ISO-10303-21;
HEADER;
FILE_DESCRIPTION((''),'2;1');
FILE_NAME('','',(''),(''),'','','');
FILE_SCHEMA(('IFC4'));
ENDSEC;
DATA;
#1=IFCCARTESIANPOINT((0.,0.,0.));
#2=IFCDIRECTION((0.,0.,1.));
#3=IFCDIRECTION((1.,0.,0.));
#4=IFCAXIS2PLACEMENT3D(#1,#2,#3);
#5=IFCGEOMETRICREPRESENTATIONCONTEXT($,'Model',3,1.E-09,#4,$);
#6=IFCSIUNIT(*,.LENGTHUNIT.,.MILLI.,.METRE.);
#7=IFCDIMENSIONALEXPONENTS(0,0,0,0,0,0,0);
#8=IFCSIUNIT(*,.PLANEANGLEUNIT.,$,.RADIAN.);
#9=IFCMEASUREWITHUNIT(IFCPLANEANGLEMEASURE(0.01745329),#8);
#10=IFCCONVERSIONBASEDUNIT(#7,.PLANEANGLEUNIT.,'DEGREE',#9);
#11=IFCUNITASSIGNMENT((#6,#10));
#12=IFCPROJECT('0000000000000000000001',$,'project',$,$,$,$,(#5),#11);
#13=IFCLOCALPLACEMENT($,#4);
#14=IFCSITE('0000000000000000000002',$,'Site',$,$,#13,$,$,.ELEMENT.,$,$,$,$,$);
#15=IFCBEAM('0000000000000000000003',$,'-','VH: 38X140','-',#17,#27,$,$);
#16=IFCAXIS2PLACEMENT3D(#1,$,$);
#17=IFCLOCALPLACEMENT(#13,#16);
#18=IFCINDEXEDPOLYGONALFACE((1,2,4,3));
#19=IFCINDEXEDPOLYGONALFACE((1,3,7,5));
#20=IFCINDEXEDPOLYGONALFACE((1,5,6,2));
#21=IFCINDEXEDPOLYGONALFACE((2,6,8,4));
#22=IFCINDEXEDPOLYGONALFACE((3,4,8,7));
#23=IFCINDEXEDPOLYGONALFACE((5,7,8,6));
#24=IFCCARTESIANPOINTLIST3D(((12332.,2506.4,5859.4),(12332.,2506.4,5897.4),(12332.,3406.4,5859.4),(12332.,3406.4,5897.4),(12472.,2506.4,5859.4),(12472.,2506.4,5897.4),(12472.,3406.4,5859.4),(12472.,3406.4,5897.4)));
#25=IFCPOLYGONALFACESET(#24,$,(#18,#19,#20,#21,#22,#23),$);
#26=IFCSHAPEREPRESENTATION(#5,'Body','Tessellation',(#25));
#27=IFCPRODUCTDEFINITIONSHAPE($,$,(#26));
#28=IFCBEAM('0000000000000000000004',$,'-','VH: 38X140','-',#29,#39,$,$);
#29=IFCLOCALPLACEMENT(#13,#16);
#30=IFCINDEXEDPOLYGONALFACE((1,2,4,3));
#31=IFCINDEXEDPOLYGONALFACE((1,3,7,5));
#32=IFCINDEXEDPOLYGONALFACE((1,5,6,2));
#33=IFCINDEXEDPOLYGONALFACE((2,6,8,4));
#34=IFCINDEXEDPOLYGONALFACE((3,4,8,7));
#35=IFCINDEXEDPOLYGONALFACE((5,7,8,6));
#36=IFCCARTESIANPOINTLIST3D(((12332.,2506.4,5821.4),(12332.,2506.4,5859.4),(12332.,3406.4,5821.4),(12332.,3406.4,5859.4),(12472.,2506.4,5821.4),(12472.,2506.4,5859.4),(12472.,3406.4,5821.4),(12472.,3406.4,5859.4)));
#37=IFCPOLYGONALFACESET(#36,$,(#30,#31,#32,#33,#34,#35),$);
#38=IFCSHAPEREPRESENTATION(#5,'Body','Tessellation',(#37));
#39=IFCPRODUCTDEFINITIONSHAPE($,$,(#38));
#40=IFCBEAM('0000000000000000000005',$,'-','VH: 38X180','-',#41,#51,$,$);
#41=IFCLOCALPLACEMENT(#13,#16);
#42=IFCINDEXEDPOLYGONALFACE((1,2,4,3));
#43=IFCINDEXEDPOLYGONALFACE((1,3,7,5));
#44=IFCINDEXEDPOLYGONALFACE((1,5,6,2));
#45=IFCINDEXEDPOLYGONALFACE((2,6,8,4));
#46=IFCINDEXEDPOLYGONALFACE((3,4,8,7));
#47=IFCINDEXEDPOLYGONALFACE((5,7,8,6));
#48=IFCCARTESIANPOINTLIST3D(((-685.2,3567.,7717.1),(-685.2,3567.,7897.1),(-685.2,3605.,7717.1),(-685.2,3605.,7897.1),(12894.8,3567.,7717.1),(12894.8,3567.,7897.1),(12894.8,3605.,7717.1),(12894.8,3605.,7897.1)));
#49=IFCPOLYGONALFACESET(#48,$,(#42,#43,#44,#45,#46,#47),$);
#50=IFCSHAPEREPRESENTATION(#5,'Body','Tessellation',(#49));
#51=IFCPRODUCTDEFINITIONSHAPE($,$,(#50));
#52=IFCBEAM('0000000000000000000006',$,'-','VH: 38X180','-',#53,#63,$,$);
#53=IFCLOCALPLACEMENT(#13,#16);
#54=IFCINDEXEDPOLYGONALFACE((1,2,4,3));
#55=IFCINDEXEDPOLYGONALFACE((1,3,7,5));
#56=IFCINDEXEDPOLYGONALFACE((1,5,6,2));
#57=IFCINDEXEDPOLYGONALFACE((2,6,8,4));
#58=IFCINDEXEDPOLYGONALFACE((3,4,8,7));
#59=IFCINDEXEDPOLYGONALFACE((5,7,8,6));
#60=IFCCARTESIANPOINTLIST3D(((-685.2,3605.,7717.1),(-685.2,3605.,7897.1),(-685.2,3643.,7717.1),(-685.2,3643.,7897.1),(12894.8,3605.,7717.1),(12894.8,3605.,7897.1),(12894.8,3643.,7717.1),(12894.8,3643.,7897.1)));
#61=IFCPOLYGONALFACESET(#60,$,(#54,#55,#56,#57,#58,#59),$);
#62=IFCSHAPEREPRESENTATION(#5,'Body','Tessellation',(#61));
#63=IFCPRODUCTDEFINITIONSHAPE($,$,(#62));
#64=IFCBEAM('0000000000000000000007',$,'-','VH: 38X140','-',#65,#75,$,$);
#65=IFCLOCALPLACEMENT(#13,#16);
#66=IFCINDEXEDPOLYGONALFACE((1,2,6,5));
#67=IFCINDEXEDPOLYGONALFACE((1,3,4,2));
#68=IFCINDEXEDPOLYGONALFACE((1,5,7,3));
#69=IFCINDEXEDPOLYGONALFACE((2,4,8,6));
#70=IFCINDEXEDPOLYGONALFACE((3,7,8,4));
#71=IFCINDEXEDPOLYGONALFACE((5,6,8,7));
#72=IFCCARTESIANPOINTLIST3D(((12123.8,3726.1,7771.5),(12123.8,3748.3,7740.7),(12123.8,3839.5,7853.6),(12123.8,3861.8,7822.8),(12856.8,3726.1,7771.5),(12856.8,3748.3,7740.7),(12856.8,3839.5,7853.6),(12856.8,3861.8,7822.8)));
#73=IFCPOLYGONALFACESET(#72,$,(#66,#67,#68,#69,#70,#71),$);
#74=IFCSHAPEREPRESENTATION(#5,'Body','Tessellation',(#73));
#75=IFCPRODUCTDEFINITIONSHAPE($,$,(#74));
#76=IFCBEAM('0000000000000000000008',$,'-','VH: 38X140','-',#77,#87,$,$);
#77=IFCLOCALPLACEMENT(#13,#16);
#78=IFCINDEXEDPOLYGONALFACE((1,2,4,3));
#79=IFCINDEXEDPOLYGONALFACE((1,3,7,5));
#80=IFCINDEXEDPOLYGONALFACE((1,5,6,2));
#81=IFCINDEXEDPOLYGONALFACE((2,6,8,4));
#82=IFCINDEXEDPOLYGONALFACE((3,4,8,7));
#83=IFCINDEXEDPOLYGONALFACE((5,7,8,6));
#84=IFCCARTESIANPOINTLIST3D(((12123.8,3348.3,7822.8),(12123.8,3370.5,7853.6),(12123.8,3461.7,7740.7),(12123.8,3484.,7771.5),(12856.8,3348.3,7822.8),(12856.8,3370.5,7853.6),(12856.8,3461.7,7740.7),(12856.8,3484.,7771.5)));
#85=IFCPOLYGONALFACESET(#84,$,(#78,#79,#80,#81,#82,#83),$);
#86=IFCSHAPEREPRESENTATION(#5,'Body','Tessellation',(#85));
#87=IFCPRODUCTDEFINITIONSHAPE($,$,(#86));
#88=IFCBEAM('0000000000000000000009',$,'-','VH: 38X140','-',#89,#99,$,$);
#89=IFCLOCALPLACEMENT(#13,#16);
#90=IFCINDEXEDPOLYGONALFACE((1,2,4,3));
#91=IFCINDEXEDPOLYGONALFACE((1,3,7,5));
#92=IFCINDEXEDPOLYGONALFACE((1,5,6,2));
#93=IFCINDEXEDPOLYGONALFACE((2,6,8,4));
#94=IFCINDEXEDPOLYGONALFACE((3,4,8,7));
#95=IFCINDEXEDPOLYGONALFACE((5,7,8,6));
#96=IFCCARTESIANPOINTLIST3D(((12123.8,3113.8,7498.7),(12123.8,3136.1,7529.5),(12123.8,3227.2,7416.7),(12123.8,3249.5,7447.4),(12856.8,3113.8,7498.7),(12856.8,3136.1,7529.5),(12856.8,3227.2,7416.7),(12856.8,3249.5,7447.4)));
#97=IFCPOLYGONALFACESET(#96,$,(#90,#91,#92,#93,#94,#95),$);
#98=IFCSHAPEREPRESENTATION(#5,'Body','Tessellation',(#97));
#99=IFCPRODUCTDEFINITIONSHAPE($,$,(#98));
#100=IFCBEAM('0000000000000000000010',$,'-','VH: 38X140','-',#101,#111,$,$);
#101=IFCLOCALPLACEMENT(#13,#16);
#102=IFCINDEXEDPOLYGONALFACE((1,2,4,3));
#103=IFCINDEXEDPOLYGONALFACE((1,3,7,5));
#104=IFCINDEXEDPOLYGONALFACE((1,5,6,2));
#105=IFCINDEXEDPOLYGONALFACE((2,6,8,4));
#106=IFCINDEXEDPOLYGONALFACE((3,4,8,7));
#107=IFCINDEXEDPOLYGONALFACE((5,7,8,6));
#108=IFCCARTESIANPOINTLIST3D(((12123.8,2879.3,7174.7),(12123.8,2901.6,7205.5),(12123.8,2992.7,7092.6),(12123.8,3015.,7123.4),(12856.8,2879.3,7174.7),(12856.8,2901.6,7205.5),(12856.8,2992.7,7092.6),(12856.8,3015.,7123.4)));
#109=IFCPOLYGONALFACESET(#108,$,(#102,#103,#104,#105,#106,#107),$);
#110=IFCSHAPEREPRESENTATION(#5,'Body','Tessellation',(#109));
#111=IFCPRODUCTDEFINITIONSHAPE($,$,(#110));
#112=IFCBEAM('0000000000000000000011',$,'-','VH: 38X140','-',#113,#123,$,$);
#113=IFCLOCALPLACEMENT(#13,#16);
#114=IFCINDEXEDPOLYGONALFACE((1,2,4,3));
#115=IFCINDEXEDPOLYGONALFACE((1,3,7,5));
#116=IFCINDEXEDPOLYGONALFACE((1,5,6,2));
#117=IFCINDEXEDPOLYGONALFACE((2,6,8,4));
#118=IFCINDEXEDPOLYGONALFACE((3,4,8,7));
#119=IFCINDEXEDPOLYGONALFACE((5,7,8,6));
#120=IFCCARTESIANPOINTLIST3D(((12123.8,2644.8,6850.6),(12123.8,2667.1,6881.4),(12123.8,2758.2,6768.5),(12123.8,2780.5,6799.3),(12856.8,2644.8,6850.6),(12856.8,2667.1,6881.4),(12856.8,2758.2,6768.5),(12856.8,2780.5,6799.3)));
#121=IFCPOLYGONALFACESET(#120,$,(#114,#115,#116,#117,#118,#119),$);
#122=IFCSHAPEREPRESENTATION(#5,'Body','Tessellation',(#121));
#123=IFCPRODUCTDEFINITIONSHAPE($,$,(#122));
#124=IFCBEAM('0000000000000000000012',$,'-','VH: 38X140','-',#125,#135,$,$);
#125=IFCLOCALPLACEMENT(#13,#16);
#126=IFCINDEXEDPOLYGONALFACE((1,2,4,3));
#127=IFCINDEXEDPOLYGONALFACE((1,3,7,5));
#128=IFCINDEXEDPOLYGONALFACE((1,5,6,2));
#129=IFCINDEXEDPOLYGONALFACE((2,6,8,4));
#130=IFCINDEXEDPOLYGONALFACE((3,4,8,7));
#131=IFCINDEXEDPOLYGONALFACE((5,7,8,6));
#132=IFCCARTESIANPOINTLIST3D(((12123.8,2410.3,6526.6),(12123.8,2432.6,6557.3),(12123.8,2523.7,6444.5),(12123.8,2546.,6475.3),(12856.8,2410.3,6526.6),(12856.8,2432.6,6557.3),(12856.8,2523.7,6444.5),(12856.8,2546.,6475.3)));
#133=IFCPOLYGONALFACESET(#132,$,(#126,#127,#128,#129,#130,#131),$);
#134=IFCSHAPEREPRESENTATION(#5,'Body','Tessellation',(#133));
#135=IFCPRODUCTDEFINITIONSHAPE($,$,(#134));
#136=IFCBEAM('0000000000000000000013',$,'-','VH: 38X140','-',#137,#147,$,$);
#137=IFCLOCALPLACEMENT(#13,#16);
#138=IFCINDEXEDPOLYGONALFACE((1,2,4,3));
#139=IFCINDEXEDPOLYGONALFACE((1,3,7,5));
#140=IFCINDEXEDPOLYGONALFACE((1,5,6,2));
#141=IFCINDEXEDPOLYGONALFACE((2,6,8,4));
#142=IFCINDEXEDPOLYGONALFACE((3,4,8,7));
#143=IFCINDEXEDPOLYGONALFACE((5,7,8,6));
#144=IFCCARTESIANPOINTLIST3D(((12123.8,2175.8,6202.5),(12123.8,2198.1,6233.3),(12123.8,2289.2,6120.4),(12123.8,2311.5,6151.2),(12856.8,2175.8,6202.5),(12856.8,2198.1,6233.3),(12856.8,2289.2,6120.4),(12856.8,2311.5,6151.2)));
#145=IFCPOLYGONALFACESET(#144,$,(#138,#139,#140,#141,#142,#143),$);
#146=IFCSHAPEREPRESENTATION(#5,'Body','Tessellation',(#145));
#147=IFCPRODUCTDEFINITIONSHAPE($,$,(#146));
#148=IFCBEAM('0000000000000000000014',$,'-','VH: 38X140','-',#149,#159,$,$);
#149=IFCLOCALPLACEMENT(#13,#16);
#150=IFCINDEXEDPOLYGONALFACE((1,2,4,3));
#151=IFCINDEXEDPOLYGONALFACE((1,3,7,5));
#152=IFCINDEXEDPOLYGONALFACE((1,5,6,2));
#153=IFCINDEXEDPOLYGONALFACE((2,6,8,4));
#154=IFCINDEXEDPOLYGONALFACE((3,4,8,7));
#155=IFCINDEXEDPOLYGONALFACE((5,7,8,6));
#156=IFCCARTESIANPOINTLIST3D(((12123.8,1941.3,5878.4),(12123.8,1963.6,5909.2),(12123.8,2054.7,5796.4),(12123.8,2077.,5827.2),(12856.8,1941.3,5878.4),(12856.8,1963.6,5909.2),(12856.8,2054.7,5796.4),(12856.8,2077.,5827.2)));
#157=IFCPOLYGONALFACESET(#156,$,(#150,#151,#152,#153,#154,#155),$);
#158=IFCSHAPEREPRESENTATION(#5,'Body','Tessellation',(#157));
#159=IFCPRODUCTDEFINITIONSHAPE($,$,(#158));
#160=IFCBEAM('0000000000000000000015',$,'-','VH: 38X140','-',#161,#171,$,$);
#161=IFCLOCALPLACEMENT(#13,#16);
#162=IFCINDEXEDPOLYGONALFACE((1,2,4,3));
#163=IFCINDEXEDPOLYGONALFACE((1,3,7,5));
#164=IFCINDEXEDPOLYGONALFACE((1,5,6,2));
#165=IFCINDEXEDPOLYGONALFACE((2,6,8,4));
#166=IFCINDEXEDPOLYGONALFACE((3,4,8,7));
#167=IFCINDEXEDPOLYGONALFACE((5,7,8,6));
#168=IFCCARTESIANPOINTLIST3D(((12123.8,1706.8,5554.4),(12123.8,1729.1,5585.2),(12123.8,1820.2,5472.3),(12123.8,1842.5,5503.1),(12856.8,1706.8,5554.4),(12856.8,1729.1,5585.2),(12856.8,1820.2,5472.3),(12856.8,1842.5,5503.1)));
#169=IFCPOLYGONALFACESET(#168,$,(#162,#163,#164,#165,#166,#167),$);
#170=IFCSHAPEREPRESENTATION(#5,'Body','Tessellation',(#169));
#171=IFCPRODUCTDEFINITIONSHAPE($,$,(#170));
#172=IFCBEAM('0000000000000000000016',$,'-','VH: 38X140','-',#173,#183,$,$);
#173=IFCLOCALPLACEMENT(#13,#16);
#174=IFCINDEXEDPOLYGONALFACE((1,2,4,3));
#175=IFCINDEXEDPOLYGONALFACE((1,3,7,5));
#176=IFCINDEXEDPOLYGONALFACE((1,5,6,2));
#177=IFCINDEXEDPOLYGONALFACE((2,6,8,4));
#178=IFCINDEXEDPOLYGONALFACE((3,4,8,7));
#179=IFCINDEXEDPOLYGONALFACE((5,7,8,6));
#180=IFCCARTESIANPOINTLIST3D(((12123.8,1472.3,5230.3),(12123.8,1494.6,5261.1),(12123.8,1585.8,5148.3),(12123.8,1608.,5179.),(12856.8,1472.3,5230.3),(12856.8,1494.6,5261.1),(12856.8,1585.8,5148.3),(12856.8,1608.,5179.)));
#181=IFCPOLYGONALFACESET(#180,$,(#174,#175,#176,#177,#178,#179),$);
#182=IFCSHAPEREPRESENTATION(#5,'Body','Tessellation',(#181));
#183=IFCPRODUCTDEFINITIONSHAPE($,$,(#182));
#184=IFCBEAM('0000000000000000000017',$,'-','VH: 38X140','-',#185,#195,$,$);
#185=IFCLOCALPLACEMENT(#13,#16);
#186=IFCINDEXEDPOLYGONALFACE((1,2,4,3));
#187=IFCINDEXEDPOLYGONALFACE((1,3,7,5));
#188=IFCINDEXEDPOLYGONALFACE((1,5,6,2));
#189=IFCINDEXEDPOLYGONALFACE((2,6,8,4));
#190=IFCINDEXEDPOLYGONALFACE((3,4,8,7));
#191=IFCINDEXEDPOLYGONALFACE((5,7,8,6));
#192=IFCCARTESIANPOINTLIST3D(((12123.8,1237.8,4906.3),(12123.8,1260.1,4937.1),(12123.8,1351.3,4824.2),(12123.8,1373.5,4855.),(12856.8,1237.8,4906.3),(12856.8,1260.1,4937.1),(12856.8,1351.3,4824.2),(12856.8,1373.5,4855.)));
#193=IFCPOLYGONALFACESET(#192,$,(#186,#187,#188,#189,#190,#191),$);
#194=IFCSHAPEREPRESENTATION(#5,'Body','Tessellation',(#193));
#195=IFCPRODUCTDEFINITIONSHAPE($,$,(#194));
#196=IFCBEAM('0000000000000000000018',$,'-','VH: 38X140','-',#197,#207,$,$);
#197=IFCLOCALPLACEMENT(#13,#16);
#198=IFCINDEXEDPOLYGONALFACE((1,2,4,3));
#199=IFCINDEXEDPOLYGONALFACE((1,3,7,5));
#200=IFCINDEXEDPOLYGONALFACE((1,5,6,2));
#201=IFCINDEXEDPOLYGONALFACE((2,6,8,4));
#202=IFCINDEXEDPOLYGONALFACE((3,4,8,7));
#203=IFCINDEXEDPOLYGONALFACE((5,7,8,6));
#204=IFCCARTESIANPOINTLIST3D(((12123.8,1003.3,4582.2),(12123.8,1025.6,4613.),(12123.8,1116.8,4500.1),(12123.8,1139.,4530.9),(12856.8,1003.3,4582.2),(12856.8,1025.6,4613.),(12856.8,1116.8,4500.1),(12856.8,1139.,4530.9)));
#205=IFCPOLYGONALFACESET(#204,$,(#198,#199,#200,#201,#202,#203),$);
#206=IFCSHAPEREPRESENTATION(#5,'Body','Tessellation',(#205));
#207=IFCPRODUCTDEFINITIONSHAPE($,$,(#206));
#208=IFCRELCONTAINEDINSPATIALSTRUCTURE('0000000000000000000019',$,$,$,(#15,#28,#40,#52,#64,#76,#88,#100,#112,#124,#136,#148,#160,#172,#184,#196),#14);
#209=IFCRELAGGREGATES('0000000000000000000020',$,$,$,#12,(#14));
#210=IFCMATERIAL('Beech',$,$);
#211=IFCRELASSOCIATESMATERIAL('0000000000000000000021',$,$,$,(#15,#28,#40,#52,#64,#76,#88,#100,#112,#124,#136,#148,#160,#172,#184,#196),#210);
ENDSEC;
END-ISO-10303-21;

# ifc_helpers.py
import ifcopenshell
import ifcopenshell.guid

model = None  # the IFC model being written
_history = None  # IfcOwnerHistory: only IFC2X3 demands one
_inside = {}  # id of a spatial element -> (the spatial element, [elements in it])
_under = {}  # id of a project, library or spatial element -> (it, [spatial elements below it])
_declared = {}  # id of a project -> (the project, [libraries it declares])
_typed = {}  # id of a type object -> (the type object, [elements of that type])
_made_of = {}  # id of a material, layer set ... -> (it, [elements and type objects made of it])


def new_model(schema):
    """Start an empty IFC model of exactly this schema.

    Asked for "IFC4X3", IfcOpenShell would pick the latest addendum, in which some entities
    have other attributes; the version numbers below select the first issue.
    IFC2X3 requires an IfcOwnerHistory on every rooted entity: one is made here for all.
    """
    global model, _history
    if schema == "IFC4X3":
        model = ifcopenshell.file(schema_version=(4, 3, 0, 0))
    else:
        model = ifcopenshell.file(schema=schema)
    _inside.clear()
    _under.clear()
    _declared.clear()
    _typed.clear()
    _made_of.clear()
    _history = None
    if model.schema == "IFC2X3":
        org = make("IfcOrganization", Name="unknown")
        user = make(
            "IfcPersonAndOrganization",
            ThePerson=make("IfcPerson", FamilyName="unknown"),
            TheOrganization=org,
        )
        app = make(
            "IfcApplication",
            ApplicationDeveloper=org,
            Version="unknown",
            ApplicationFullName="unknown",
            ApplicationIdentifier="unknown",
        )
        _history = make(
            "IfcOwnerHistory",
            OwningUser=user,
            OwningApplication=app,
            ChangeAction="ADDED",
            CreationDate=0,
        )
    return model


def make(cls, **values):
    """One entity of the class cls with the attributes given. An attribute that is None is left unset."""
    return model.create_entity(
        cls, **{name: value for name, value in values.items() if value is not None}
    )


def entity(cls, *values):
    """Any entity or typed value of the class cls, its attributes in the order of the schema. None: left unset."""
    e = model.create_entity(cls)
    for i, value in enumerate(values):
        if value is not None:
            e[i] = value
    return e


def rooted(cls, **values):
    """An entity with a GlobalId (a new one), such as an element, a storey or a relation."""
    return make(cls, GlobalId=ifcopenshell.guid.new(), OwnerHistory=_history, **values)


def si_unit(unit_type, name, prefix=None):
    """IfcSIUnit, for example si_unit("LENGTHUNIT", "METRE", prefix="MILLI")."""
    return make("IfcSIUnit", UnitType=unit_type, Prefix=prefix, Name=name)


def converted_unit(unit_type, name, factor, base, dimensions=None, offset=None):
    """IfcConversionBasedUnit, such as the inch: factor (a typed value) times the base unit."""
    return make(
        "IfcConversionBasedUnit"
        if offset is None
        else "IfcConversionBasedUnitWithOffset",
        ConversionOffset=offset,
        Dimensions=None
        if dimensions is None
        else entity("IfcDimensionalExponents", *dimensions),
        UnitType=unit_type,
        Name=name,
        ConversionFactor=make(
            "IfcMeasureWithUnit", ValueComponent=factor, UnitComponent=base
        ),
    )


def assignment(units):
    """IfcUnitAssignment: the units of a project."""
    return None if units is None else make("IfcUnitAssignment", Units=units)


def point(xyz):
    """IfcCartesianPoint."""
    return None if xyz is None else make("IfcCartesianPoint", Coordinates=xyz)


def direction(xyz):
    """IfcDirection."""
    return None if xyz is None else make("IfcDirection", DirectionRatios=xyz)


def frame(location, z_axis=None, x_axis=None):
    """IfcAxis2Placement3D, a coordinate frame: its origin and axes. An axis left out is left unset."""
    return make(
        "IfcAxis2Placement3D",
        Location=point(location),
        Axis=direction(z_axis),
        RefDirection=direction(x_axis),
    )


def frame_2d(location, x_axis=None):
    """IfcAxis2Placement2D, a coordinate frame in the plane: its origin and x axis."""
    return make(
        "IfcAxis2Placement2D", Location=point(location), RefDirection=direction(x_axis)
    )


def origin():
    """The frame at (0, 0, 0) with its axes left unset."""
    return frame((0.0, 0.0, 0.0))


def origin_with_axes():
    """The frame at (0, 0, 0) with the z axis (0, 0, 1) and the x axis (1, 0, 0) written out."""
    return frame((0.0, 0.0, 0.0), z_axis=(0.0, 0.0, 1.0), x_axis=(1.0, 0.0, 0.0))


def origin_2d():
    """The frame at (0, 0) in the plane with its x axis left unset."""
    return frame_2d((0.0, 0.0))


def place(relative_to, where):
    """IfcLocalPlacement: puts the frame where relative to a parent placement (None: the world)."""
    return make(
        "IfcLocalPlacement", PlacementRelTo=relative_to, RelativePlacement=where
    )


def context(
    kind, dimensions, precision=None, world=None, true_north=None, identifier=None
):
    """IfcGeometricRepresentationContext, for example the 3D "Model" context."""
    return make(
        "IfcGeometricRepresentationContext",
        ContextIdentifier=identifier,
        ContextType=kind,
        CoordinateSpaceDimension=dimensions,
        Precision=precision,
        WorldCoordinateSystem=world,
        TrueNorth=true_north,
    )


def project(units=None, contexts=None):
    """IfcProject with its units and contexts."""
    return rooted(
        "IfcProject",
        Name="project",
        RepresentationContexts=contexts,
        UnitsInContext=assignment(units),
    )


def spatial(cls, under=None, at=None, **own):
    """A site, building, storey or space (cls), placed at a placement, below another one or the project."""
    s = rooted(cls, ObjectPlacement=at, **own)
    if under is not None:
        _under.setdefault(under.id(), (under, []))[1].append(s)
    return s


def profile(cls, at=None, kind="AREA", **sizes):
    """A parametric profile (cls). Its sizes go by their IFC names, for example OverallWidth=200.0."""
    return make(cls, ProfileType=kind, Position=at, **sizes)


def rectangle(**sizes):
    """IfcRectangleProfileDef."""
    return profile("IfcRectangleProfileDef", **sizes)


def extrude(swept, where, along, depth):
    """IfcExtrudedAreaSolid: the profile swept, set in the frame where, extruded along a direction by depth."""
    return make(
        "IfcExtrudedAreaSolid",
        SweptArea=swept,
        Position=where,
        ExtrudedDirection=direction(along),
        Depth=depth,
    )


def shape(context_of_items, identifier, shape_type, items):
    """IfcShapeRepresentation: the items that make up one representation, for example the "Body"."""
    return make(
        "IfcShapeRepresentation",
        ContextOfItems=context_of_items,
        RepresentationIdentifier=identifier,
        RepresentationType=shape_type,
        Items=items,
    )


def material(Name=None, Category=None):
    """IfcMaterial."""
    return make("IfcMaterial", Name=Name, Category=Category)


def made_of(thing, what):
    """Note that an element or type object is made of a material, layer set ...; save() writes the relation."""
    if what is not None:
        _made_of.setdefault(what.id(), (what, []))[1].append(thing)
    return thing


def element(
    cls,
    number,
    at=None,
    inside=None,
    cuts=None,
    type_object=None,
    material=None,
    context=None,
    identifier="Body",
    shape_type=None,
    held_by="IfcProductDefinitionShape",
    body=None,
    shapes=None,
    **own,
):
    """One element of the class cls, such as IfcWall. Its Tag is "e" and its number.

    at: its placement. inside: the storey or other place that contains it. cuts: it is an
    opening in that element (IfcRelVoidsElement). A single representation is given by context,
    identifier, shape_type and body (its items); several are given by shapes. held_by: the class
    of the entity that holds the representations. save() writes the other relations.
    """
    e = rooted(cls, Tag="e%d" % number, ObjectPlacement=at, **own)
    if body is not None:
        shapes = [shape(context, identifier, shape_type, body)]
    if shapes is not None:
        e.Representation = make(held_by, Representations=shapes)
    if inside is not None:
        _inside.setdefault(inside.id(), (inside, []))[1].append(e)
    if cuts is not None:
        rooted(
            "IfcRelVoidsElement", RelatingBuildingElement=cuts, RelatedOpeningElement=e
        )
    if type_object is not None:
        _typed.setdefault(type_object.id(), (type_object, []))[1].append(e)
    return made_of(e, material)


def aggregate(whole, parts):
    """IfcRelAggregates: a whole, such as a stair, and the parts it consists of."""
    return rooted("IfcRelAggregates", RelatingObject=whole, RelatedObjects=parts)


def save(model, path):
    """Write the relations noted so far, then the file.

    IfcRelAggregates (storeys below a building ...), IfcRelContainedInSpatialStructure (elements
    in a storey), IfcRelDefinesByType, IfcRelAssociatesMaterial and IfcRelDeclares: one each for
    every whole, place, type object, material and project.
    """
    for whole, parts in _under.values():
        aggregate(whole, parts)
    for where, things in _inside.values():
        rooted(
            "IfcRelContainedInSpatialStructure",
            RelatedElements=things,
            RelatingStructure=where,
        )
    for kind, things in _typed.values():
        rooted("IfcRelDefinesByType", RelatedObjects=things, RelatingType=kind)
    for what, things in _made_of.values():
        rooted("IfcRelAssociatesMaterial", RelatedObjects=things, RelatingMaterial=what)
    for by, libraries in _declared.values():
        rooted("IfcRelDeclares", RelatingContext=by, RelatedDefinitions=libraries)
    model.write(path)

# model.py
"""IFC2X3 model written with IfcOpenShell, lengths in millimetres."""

from ifc_helpers import new_model, entity, si_unit, converted_unit, frame, origin, origin_with_axes, origin_2d, place, context, project, spatial, rectangle, extrude, material, element, save


model = new_model("IFC2X3")

# Units and contexts
model_context = context("Model", 3, precision=1e-09, world=origin_with_axes())
ifc_project = project(units=[si_unit("LENGTHUNIT", "METRE", prefix="MILLI"), converted_unit("PLANEANGLEUNIT", "DEGREE", entity("IfcPlaneAngleMeasure", 0.01745329), si_unit("PLANEANGLEUNIT", "RADIAN"), dimensions=[0, 0, 0, 0, 0, 0, 0])], contexts=[model_context])

# Site
site_placement = place(None, origin_with_axes())
site = spatial("IfcSite", under=ifc_project, at=site_placement, Name="Site", CompositionType="ELEMENT")

# Shared definitions
ifc_material = material(Name="Beech")

# Beams
for number, where, z_axis, x_axis, name in (
    (1, (12402.0, 3406.4, 5878.4), (0.0, -1.0, 0.0), (0.0, 0.0, -1.0), "-"),
    (2, (12402.0, 3406.4, 5840.4), (0.0, -1.0, 0.0), (0.0, 0.0, -1.0), "-"),
):
    element("IfcBeam", number, at=place(None, frame(where, z_axis=z_axis, x_axis=x_axis)), inside=site, material=ifc_material, Name=name, Description="VH: 38X140", ObjectType="-", context=model_context, shape_type="SweptSolid", body=[
        extrude(rectangle(XDim=38.0, YDim=140.0, at=origin_2d()), origin(), (0.0, 0.0, 1.0), 900.0),
    ])
for number, where, z_axis, x_axis, name in (
    (3, (12894.8, 3586.0, 7807.1), (-1.0, 0.0, 0.0), (0.0, -1.0, 0.0), "-"),
    (4, (12894.8, 3624.0, 7807.1), (-1.0, 0.0, 0.0), (0.0, -1.0, 0.0), "-"),
):
    element("IfcBeam", number, at=place(None, frame(where, z_axis=z_axis, x_axis=x_axis)), inside=site, material=ifc_material, Name=name, Description="VH: 38X180", ObjectType="-", context=model_context, shape_type="SweptSolid", body=[
        extrude(rectangle(XDim=38.0, YDim=180.0, at=origin_2d()), origin(), (0.0, 0.0, 1.0), 13580.0),
    ])
beam_placement = place(None, frame((12856.8, 3793.9, 7797.2), z_axis=(-1.0, 0.0, 0.0), x_axis=(0.0, -0.58623, 0.810145)))
element("IfcBeam", 5, at=beam_placement, inside=site, material=ifc_material, Name="-", Description="VH: 38X140", ObjectType="-", context=model_context, shape_type="SweptSolid", body=[
    extrude(rectangle(XDim=38.0, YDim=140.0, at=origin_2d()), origin(), (0.0, 0.0, 1.0), 733.0),
])
for number, where, z_axis, x_axis, name in (
    (6, (12856.8, 3416.1, 7797.2), (1.0, 0.0, 0.0), (0.0, 0.58623, 0.810145), "-"),
    (7, (12856.8, 3181.6, 7473.1), (1.0, 0.0, 0.0), (0.0, 0.58623, 0.810145), "-"),
    (8, (12856.8, 2947.1, 7149.0), (1.0, 0.0, 0.0), (0.0, 0.58623, 0.810145), "-"),
    (9, (12856.8, 2712.6, 6825.0), (1.0, 0.0, 0.0), (0.0, 0.58623, 0.810145), "-"),
    (10, (12856.8, 2478.1, 6500.9), (1.0, 0.0, 0.0), (0.0, 0.58623, 0.810145), "-"),
    (11, (12856.8, 2243.7, 6176.9), (1.0, 0.0, 0.0), (0.0, 0.58623, 0.810145), "-"),
    (12, (12856.8, 2009.2, 5852.8), (1.0, 0.0, 0.0), (0.0, 0.58623, 0.810145), "-"),
    (13, (12856.8, 1774.7, 5528.7), (1.0, 0.0, 0.0), (0.0, 0.58623, 0.810145), "-"),
    (14, (12856.8, 1540.2, 5204.7), (1.0, 0.0, 0.0), (0.0, 0.58623, 0.810145), "-"),
    (15, (12856.8, 1305.7, 4880.6), (1.0, 0.0, 0.0), (0.0, 0.58623, 0.810145), "-"),
    (16, (12856.8, 1071.2, 4556.6), (1.0, 0.0, 0.0), (0.0, 0.58623, 0.810145), "-"),
):
    element("IfcBeam", number, at=place(None, frame(where, z_axis=z_axis, x_axis=x_axis)), inside=site, material=ifc_material, Name=name, Description="VH: 38X140", ObjectType="-", context=model_context, shape_type="SweptSolid", body=[
        extrude(rectangle(XDim=38.0, YDim=140.0, at=origin_2d()), origin(), (0.0, 0.0, -1.0), 733.0),
    ])

save(model, "model.ifc")
